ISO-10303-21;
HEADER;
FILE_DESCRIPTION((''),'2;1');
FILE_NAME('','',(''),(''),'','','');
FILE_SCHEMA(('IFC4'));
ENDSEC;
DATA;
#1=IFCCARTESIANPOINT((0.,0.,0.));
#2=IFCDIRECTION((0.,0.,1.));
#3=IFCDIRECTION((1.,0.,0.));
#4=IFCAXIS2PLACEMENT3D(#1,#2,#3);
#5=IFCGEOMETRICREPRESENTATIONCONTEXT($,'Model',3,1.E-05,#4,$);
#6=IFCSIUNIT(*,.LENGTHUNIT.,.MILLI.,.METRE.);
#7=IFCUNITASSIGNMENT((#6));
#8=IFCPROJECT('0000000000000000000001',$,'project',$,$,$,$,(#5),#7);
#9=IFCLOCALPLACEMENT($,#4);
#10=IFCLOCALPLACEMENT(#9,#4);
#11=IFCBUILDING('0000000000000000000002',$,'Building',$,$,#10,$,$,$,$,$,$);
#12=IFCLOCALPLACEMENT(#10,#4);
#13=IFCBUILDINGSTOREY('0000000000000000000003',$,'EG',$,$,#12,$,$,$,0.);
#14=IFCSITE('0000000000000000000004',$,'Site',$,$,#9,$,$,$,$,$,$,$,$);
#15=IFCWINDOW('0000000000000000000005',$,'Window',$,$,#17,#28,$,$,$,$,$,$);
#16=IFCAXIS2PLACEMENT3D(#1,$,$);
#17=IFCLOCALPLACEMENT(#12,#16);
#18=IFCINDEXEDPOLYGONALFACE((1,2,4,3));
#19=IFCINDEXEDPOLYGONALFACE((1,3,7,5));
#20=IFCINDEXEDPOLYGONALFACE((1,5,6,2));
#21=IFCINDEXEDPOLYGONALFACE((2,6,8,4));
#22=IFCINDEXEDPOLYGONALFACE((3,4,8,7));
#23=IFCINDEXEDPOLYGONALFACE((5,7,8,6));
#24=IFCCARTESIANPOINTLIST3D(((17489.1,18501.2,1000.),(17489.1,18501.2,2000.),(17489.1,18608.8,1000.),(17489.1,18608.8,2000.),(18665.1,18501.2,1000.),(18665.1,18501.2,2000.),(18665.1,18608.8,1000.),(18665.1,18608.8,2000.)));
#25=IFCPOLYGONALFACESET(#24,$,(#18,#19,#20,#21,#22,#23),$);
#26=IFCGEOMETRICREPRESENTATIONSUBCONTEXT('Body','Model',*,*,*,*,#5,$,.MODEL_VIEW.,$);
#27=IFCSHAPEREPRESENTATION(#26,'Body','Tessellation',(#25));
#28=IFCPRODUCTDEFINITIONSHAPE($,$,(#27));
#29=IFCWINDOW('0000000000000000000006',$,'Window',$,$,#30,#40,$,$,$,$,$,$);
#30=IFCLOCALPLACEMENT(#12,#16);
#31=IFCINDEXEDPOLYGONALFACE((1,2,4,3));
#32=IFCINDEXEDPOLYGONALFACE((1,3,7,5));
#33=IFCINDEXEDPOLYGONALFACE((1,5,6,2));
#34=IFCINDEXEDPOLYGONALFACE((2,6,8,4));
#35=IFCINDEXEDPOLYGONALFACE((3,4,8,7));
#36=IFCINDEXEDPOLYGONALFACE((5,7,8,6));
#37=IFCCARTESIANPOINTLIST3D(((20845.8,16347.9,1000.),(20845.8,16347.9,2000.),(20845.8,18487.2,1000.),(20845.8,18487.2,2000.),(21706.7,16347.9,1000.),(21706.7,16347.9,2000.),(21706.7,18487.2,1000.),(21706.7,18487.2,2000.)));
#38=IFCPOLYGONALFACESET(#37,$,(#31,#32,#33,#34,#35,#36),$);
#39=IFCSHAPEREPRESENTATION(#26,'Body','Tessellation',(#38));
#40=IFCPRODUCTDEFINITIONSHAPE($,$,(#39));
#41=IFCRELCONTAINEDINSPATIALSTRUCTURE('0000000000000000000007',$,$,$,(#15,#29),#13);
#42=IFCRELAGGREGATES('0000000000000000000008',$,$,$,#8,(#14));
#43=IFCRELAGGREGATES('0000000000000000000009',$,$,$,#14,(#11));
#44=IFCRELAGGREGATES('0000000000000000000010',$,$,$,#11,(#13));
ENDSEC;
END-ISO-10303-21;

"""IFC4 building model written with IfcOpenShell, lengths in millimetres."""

from ifc_helpers import new_model, si_unit, frame, origin_with_axes, place, context, subcontext, project, spatial, rectangle, extrude, element, save


model = new_model("IFC4")

# Units and contexts
model_context = context("Model", 3, precision=1e-05, world=origin_with_axes())
body_context = subcontext(model_context, "Body", "Model", "MODEL_VIEW")
ifc_project = project(units=[si_unit("LENGTHUNIT", "METRE", prefix="MILLI")], contexts=[model_context])

# Site, building, storey
site_placement = place(None, origin_with_axes())
site = spatial("IfcSite", under=ifc_project, at=site_placement, Name="Site")
building_placement = place(site_placement, origin_with_axes())
building = spatial("IfcBuilding", under=site, at=building_placement, Name="Building")
storey_placement = place(building_placement, origin_with_axes())
storey = spatial("IfcBuildingStorey", under=building, at=storey_placement, Name="EG", Elevation=0.0)

# Windows
window_1_placement = place(storey_placement, origin_with_axes())
element("IfcWindow", 1, at=window_1_placement, inside=storey, Name="Window", context=body_context, shape_type="SweptSolid", body=[
    extrude(rectangle(XDim=1176.0, YDim=107.6), frame((18077.1, 18555.0, 1000.0), z_axis=(0.0, 0.0, 1.0), x_axis=(1.0, 0.0, 0.0)), (0.0, 0.0, 1.0), 1000.0),
])
window_2_placement = place(storey_placement, origin_with_axes())
element("IfcWindow", 2, at=window_2_placement, inside=storey, Name="Window", context=body_context, shape_type="SweptSolid", body=[
    extrude(rectangle(XDim=2139.3, YDim=860.9), frame((21276.2, 17417.6, 1000.0), z_axis=(0.0, 0.0, 1.0), x_axis=(0.0, -1.0, 0.0)), (0.0, 0.0, 1.0), 1000.0),
])

save(model, "model.ifc")
